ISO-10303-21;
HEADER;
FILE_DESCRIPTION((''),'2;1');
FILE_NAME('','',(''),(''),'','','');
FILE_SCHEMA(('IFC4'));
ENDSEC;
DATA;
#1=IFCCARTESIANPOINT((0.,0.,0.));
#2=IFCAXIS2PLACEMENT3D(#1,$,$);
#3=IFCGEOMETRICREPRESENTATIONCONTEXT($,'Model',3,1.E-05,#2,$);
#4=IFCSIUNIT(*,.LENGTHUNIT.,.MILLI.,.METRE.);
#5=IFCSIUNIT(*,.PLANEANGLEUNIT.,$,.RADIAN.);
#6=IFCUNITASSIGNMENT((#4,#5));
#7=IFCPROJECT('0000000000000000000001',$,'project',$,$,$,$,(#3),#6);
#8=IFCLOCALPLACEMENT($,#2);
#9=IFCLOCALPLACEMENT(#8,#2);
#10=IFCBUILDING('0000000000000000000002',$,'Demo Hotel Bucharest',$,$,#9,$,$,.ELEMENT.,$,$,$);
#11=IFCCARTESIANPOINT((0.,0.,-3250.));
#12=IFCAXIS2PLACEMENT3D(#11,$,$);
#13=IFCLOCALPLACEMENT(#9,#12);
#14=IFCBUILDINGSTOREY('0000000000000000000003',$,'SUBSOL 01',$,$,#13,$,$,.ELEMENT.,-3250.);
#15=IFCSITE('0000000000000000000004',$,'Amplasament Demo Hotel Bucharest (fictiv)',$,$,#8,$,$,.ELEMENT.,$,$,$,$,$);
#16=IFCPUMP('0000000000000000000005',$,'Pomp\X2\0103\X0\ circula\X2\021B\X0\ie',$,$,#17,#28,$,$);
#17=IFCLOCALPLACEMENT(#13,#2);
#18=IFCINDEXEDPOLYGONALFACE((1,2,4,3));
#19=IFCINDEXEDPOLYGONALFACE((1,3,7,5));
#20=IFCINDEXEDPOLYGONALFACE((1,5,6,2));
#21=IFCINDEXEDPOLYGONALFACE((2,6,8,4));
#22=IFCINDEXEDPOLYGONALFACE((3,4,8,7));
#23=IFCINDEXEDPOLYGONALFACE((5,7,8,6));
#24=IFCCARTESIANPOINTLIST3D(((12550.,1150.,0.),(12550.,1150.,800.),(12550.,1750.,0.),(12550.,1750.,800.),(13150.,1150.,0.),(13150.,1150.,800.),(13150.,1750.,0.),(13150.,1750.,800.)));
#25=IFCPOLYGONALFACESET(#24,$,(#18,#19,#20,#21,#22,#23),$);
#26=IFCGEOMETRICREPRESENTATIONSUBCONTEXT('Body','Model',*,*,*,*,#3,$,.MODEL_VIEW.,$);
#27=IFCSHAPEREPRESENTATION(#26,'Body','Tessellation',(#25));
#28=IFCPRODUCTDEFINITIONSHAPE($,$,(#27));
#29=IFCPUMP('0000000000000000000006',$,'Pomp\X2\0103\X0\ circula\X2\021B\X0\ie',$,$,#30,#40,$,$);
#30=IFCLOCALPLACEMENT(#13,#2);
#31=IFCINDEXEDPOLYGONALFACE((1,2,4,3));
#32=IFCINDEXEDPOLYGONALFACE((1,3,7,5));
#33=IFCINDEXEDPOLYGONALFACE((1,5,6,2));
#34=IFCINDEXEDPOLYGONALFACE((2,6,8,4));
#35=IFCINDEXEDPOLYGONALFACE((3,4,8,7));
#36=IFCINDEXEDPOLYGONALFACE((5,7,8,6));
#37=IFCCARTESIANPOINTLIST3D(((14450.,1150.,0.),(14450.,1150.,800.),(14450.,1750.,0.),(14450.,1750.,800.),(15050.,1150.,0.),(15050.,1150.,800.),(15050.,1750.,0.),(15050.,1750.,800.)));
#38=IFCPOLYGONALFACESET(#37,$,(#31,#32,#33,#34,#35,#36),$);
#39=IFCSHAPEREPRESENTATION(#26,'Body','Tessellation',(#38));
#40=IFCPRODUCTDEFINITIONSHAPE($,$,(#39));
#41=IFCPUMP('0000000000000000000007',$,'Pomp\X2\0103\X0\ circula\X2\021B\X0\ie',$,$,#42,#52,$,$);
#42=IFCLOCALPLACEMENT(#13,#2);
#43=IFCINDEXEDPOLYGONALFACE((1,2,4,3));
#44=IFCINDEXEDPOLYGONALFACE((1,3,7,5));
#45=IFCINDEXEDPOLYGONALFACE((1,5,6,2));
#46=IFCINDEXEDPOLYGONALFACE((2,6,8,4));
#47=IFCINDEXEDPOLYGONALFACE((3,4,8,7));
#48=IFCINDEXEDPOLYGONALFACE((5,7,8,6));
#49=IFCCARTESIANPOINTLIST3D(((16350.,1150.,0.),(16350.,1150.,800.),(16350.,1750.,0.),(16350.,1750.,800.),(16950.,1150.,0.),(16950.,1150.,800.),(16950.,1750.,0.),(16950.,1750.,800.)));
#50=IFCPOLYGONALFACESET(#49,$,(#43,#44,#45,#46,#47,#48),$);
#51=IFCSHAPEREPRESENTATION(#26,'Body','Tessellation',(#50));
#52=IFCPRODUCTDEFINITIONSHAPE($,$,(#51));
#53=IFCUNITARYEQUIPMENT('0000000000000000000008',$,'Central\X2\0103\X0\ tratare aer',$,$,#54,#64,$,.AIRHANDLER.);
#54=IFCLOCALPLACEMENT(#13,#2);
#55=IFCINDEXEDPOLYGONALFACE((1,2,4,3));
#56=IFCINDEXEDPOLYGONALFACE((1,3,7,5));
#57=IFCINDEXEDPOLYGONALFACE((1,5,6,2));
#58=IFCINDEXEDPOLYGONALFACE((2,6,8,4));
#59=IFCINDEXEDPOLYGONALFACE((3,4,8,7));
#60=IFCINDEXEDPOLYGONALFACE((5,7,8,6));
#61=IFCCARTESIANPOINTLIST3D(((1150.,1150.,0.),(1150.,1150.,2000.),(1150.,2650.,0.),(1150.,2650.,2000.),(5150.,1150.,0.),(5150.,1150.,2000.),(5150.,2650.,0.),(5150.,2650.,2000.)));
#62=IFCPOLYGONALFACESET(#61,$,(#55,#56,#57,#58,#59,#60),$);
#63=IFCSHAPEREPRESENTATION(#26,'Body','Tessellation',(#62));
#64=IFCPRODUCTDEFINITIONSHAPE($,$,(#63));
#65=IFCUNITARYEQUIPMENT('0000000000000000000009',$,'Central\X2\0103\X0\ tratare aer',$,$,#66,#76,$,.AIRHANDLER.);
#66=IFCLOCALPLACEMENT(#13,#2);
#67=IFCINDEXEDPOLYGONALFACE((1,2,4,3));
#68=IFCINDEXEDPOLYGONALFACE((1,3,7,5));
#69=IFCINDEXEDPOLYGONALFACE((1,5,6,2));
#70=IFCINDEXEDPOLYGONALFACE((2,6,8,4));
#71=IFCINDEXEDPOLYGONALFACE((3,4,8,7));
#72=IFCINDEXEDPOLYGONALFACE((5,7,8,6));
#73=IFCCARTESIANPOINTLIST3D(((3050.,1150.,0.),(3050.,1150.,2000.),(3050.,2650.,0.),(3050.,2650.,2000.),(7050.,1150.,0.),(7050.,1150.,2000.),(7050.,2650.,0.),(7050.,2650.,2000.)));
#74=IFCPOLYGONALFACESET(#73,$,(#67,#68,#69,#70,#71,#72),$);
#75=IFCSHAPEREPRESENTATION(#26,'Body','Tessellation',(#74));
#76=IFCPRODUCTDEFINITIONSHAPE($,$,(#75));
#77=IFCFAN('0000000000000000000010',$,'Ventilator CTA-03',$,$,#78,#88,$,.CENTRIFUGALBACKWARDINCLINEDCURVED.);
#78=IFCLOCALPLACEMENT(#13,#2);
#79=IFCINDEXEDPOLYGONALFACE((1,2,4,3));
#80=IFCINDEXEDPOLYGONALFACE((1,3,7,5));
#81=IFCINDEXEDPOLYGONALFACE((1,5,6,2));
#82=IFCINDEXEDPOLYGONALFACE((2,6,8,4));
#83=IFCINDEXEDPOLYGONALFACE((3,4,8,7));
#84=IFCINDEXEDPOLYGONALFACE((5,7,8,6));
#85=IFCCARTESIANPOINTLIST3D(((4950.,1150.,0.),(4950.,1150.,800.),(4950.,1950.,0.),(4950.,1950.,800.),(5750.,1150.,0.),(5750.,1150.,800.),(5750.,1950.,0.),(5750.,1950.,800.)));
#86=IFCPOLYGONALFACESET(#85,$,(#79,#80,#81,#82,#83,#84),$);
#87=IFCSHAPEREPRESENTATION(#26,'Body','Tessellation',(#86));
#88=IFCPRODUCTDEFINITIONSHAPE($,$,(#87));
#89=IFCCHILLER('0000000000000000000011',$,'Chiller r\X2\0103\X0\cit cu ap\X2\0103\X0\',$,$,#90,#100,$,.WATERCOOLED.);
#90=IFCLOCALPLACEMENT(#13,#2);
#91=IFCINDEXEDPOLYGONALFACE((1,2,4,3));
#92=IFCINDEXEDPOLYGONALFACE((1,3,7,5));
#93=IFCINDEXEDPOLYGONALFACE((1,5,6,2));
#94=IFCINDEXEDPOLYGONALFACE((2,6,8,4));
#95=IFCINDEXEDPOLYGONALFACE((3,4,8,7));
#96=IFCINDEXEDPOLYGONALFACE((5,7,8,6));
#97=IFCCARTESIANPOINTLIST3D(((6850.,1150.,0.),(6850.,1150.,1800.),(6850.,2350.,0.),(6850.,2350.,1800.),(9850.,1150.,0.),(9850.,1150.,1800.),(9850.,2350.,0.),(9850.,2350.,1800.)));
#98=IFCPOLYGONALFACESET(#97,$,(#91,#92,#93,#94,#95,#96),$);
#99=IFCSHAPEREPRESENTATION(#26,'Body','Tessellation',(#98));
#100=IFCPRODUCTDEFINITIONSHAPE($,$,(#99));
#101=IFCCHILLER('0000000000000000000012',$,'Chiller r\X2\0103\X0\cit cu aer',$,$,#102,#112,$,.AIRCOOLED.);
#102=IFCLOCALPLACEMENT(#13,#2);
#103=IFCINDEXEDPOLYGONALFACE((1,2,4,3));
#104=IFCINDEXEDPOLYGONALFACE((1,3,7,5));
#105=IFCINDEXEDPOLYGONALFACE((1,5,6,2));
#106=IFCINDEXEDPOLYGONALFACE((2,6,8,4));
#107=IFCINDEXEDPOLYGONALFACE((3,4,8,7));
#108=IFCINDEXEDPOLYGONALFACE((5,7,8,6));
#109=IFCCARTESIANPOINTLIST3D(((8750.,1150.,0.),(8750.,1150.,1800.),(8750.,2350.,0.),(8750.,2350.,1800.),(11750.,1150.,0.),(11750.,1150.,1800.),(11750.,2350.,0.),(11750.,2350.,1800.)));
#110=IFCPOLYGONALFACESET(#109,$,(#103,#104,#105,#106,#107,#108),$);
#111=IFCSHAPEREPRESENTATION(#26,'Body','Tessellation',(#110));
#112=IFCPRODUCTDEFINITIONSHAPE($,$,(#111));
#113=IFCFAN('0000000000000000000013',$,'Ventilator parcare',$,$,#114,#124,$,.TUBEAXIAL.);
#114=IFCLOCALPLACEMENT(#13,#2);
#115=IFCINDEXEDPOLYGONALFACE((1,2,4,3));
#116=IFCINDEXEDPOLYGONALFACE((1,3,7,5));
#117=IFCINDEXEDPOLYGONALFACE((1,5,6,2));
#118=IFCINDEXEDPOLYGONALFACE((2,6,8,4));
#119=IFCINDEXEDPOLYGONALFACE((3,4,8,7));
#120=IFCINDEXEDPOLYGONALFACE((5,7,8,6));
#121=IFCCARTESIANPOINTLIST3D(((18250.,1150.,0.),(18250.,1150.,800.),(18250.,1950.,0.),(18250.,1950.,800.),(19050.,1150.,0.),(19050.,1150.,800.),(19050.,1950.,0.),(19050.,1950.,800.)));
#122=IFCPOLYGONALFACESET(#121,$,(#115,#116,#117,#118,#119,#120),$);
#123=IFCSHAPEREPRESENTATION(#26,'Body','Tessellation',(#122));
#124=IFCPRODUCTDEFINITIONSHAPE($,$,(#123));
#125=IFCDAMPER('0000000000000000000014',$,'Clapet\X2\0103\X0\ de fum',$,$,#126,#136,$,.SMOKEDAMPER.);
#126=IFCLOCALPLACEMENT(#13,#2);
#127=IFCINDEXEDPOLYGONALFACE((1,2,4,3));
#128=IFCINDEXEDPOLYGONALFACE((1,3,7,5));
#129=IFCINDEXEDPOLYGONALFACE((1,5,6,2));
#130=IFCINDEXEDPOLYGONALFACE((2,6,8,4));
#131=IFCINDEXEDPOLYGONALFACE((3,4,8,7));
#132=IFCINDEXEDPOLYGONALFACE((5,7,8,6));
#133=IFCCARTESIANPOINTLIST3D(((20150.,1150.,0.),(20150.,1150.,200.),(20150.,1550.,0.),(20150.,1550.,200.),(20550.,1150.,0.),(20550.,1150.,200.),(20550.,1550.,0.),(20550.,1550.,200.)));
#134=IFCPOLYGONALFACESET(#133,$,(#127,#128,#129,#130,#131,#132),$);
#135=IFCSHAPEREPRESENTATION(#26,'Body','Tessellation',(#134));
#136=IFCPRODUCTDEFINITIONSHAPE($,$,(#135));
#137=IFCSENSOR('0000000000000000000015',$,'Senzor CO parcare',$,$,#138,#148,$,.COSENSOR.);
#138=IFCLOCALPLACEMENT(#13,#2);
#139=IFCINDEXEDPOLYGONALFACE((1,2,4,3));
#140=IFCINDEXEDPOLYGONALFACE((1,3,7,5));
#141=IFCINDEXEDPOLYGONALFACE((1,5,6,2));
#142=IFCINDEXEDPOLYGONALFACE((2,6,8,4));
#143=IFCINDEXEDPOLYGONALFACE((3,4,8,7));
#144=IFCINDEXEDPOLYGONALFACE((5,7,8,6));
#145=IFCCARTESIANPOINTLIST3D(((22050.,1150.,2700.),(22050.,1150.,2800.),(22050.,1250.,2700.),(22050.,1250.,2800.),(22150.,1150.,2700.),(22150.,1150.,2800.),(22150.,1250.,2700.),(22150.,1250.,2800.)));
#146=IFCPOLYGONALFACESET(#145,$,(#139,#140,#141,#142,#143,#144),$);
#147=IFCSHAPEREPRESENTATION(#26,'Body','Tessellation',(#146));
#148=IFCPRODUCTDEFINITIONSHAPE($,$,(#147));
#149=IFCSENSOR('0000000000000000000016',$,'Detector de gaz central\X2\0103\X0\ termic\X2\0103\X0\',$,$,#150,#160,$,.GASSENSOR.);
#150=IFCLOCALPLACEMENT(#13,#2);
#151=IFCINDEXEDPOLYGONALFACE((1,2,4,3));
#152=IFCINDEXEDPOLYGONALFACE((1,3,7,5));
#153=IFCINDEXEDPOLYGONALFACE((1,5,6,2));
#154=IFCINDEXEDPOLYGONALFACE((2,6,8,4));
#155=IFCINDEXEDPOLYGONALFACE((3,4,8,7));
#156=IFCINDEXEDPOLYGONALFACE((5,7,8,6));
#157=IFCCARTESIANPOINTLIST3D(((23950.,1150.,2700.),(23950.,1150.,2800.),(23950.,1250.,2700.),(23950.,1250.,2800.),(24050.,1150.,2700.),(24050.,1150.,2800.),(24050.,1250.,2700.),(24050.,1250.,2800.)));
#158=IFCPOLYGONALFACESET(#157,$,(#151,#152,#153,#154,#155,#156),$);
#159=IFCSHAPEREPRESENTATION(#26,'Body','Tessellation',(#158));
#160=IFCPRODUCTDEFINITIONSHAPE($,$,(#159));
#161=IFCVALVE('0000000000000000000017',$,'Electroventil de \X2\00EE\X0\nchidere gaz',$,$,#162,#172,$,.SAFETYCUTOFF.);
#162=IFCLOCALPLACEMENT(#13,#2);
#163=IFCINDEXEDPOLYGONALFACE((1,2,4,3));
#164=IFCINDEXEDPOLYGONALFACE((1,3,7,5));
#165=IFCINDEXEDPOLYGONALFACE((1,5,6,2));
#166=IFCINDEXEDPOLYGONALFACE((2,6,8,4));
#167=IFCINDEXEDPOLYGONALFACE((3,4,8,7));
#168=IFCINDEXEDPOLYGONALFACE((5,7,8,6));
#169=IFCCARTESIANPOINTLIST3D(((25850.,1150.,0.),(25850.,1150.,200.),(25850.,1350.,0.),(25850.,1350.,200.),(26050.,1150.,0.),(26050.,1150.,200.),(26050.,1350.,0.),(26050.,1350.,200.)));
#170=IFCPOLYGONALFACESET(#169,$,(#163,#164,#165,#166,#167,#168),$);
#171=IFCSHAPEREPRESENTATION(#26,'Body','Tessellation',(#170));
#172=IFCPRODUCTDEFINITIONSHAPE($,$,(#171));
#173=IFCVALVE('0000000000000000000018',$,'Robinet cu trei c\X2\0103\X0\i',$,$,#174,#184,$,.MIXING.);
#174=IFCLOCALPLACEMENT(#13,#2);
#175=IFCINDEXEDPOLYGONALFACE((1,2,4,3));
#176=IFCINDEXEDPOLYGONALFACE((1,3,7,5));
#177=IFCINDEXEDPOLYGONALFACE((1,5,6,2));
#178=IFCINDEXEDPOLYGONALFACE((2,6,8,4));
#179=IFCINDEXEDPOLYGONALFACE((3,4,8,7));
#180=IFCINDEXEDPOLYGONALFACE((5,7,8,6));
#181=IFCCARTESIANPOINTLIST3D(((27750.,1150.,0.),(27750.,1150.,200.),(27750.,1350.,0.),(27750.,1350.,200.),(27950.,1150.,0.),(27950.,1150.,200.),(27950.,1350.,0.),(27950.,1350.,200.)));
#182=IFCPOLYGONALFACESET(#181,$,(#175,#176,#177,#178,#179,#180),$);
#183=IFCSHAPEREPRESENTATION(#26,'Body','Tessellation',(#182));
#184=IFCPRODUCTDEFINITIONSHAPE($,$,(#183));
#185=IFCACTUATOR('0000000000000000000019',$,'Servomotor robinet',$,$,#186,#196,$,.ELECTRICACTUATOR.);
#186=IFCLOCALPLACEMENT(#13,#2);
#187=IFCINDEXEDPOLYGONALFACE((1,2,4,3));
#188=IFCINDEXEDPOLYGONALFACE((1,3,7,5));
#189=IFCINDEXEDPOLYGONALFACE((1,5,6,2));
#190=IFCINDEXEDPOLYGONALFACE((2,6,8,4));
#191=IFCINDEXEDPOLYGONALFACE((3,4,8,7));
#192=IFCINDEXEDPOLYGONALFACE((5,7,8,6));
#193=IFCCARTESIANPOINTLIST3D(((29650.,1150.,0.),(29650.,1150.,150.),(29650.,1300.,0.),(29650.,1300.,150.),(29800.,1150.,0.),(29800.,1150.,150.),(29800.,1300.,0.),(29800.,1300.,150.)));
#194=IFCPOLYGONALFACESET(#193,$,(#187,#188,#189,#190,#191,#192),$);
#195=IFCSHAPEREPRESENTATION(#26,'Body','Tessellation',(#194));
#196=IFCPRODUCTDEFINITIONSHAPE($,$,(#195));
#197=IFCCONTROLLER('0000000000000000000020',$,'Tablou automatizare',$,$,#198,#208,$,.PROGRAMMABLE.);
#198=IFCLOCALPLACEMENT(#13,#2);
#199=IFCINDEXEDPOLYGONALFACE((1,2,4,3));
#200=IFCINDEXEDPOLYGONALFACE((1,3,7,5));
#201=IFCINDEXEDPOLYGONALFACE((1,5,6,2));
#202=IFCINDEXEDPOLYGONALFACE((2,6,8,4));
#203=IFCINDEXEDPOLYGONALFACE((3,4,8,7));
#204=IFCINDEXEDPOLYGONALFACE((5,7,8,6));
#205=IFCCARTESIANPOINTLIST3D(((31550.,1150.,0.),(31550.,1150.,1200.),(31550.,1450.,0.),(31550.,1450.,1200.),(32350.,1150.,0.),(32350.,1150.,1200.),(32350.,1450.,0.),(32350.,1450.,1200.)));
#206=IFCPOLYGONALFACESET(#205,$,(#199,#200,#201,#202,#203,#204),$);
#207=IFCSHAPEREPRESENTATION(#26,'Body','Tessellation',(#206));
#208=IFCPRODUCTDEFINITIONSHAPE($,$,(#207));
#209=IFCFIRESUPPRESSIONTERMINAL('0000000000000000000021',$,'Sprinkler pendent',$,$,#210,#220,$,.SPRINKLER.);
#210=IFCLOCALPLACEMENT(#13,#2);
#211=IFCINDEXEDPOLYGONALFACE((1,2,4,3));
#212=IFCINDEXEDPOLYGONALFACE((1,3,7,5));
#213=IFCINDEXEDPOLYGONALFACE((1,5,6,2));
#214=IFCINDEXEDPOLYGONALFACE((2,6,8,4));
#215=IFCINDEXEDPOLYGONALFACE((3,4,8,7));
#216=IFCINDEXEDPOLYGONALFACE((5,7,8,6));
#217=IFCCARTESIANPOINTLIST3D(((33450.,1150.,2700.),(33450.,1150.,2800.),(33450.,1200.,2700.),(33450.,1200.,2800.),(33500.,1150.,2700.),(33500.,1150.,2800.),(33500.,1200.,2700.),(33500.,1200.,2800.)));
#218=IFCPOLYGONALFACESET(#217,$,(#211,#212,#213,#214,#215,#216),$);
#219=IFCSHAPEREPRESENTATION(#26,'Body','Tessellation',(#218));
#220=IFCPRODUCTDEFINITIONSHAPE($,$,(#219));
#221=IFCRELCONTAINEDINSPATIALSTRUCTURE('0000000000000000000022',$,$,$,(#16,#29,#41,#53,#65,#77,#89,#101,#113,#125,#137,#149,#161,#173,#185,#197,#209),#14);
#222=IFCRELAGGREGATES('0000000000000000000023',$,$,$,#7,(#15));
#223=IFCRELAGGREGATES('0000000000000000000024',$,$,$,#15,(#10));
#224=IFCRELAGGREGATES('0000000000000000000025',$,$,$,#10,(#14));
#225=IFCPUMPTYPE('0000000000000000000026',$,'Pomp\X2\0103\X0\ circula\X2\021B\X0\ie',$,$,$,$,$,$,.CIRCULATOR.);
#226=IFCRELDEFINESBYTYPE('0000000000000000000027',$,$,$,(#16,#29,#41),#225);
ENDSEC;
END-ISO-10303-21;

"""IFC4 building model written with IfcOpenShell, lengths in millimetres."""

from ifc_helpers import new_model, si_unit, frame, frame_2d, origin, place, context, subcontext, project, spatial, rectangle, extrude, type_object, element, save


model = new_model("IFC4")

# Units and contexts
model_context = context("Model", 3, precision=1e-05, world=origin())
body_context = subcontext(model_context, "Body", "Model", "MODEL_VIEW")
ifc_project = project(units=[si_unit("LENGTHUNIT", "METRE", prefix="MILLI"), si_unit("PLANEANGLEUNIT", "RADIAN")], contexts=[model_context])

# Site, building, storey
site_placement = place(None, origin())
site = spatial("IfcSite", under=ifc_project, at=site_placement, Name="Amplasament Demo Hotel Bucharest (fictiv)", CompositionType="ELEMENT")
building_placement = place(site_placement, origin())
building = spatial("IfcBuilding", under=site, at=building_placement, Name="Demo Hotel Bucharest", CompositionType="ELEMENT")
storey_placement = place(building_placement, frame((0.0, 0.0, -3250.0)))
storey = spatial("IfcBuildingStorey", under=building, at=storey_placement, Name="SUBSOL 01", CompositionType="ELEMENT", Elevation=-3250.0)

# Pumps
pump_type = type_object("IfcPumpType", Name="Pompă circulație", PredefinedType="CIRCULATOR")
for number, where, name in (
    (1, (12550.0, 1150.0, 0.0), "Pompă circulație"),
    (2, (14450.0, 1150.0, 0.0), "Pompă circulație"),
    (3, (16350.0, 1150.0, 0.0), "Pompă circulație"),
):
    element("IfcPump", number, at=place(storey_placement, frame(where)), inside=storey, type_object=pump_type, Name=name, context=body_context, shape_type="SweptSolid", body=[
        extrude(rectangle(XDim=600.0, YDim=600.0, at=frame_2d((300.0, 300.0))), origin(), (0.0, 0.0, 1.0), 800.0),
    ])

# Unitary equipment
for number, where, name in (
    (4, (1150.0, 1150.0, 0.0), "Centrală tratare aer"),
    (5, (3050.0, 1150.0, 0.0), "Centrală tratare aer"),
):
    element("IfcUnitaryEquipment", number, at=place(storey_placement, frame(where)), inside=storey, Name=name, PredefinedType="AIRHANDLER", context=body_context, shape_type="SweptSolid", body=[
        extrude(rectangle(XDim=4000.0, YDim=1500.0, at=frame_2d((2000.0, 750.0))), origin(), (0.0, 0.0, 1.0), 2000.0),
    ])

# Fan
fan_1_placement = place(storey_placement, frame((4950.0, 1150.0, 0.0)))
element("IfcFan", 6, at=fan_1_placement, inside=storey, Name="Ventilator CTA-03", PredefinedType="CENTRIFUGALBACKWARDINCLINEDCURVED", context=body_context, shape_type="SweptSolid", body=[
    extrude(rectangle(XDim=800.0, YDim=800.0, at=frame_2d((400.0, 400.0))), origin(), (0.0, 0.0, 1.0), 800.0),
])

# Chillers
chiller_1_placement = place(storey_placement, frame((6850.0, 1150.0, 0.0)))
element("IfcChiller", 7, at=chiller_1_placement, inside=storey, Name="Chiller răcit cu apă", PredefinedType="WATERCOOLED", context=body_context, shape_type="SweptSolid", body=[
    extrude(rectangle(XDim=3000.0, YDim=1200.0, at=frame_2d((1500.0, 600.0))), origin(), (0.0, 0.0, 1.0), 1800.0),
])
chiller_2_placement = place(storey_placement, frame((8750.0, 1150.0, 0.0)))
element("IfcChiller", 8, at=chiller_2_placement, inside=storey, Name="Chiller răcit cu aer", PredefinedType="AIRCOOLED", context=body_context, shape_type="SweptSolid", body=[
    extrude(rectangle(XDim=3000.0, YDim=1200.0, at=frame_2d((1500.0, 600.0))), origin(), (0.0, 0.0, 1.0), 1800.0),
])

# Fan
fan_2_placement = place(storey_placement, frame((18250.0, 1150.0, 0.0)))
element("IfcFan", 9, at=fan_2_placement, inside=storey, Name="Ventilator parcare", PredefinedType="TUBEAXIAL", context=body_context, shape_type="SweptSolid", body=[
    extrude(rectangle(XDim=800.0, YDim=800.0, at=frame_2d((400.0, 400.0))), origin(), (0.0, 0.0, 1.0), 800.0),
])

# Damper
damper_placement = place(storey_placement, frame((20150.0, 1150.0, 0.0)))
element("IfcDamper", 10, at=damper_placement, inside=storey, Name="Clapetă de fum", PredefinedType="SMOKEDAMPER", context=body_context, shape_type="SweptSolid", body=[
    extrude(rectangle(XDim=400.0, YDim=400.0, at=frame_2d((200.0, 200.0))), origin(), (0.0, 0.0, 1.0), 200.0),
])

# Sensors
sensor_1_placement = place(storey_placement, frame((22050.0, 1150.0, 2700.0)))
element("IfcSensor", 11, at=sensor_1_placement, inside=storey, Name="Senzor CO parcare", PredefinedType="COSENSOR", context=body_context, shape_type="SweptSolid", body=[
    extrude(rectangle(XDim=100.0, YDim=100.0, at=frame_2d((50.0, 50.0))), origin(), (0.0, 0.0, 1.0), 100.0),
])
sensor_2_placement = place(storey_placement, frame((23950.0, 1150.0, 2700.0)))
element("IfcSensor", 12, at=sensor_2_placement, inside=storey, Name="Detector de gaz centrală termică", PredefinedType="GASSENSOR", context=body_context, shape_type="SweptSolid", body=[
    extrude(rectangle(XDim=100.0, YDim=100.0, at=frame_2d((50.0, 50.0))), origin(), (0.0, 0.0, 1.0), 100.0),
])

# Valves
valve_1_placement = place(storey_placement, frame((25850.0, 1150.0, 0.0)))
element("IfcValve", 13, at=valve_1_placement, inside=storey, Name="Electroventil de închidere gaz", PredefinedType="SAFETYCUTOFF", context=body_context, shape_type="SweptSolid", body=[
    extrude(rectangle(XDim=200.0, YDim=200.0, at=frame_2d((100.0, 100.0))), origin(), (0.0, 0.0, 1.0), 200.0),
])
valve_2_placement = place(storey_placement, frame((27750.0, 1150.0, 0.0)))
element("IfcValve", 14, at=valve_2_placement, inside=storey, Name="Robinet cu trei căi", PredefinedType="MIXING", context=body_context, shape_type="SweptSolid", body=[
    extrude(rectangle(XDim=200.0, YDim=200.0, at=frame_2d((100.0, 100.0))), origin(), (0.0, 0.0, 1.0), 200.0),
])

# Actuator
actuator_placement = place(storey_placement, frame((29650.0, 1150.0, 0.0)))
element("IfcActuator", 15, at=actuator_placement, inside=storey, Name="Servomotor robinet", PredefinedType="ELECTRICACTUATOR", context=body_context, shape_type="SweptSolid", body=[
    extrude(rectangle(XDim=150.0, YDim=150.0, at=frame_2d((75.0, 75.0))), origin(), (0.0, 0.0, 1.0), 150.0),
])

# Controller
controller_placement = place(storey_placement, frame((31550.0, 1150.0, 0.0)))
element("IfcController", 16, at=controller_placement, inside=storey, Name="Tablou automatizare", PredefinedType="PROGRAMMABLE", context=body_context, shape_type="SweptSolid", body=[
    extrude(rectangle(XDim=800.0, YDim=300.0, at=frame_2d((400.0, 150.0))), origin(), (0.0, 0.0, 1.0), 1200.0),
])

# Fire suppression terminal
for number, where, name in (
    (17, (33450.0, 1150.0, 2700.0), "Sprinkler pendent"),
):
    element("IfcFireSuppressionTerminal", number, at=place(storey_placement, frame(where)), inside=storey, Name=name, PredefinedType="SPRINKLER", context=body_context, shape_type="SweptSolid", body=[
        extrude(rectangle(XDim=50.0, YDim=50.0, at=frame_2d((25.0, 25.0))), origin(), (0.0, 0.0, 1.0), 100.0),
    ])

save(model, "model.ifc")
